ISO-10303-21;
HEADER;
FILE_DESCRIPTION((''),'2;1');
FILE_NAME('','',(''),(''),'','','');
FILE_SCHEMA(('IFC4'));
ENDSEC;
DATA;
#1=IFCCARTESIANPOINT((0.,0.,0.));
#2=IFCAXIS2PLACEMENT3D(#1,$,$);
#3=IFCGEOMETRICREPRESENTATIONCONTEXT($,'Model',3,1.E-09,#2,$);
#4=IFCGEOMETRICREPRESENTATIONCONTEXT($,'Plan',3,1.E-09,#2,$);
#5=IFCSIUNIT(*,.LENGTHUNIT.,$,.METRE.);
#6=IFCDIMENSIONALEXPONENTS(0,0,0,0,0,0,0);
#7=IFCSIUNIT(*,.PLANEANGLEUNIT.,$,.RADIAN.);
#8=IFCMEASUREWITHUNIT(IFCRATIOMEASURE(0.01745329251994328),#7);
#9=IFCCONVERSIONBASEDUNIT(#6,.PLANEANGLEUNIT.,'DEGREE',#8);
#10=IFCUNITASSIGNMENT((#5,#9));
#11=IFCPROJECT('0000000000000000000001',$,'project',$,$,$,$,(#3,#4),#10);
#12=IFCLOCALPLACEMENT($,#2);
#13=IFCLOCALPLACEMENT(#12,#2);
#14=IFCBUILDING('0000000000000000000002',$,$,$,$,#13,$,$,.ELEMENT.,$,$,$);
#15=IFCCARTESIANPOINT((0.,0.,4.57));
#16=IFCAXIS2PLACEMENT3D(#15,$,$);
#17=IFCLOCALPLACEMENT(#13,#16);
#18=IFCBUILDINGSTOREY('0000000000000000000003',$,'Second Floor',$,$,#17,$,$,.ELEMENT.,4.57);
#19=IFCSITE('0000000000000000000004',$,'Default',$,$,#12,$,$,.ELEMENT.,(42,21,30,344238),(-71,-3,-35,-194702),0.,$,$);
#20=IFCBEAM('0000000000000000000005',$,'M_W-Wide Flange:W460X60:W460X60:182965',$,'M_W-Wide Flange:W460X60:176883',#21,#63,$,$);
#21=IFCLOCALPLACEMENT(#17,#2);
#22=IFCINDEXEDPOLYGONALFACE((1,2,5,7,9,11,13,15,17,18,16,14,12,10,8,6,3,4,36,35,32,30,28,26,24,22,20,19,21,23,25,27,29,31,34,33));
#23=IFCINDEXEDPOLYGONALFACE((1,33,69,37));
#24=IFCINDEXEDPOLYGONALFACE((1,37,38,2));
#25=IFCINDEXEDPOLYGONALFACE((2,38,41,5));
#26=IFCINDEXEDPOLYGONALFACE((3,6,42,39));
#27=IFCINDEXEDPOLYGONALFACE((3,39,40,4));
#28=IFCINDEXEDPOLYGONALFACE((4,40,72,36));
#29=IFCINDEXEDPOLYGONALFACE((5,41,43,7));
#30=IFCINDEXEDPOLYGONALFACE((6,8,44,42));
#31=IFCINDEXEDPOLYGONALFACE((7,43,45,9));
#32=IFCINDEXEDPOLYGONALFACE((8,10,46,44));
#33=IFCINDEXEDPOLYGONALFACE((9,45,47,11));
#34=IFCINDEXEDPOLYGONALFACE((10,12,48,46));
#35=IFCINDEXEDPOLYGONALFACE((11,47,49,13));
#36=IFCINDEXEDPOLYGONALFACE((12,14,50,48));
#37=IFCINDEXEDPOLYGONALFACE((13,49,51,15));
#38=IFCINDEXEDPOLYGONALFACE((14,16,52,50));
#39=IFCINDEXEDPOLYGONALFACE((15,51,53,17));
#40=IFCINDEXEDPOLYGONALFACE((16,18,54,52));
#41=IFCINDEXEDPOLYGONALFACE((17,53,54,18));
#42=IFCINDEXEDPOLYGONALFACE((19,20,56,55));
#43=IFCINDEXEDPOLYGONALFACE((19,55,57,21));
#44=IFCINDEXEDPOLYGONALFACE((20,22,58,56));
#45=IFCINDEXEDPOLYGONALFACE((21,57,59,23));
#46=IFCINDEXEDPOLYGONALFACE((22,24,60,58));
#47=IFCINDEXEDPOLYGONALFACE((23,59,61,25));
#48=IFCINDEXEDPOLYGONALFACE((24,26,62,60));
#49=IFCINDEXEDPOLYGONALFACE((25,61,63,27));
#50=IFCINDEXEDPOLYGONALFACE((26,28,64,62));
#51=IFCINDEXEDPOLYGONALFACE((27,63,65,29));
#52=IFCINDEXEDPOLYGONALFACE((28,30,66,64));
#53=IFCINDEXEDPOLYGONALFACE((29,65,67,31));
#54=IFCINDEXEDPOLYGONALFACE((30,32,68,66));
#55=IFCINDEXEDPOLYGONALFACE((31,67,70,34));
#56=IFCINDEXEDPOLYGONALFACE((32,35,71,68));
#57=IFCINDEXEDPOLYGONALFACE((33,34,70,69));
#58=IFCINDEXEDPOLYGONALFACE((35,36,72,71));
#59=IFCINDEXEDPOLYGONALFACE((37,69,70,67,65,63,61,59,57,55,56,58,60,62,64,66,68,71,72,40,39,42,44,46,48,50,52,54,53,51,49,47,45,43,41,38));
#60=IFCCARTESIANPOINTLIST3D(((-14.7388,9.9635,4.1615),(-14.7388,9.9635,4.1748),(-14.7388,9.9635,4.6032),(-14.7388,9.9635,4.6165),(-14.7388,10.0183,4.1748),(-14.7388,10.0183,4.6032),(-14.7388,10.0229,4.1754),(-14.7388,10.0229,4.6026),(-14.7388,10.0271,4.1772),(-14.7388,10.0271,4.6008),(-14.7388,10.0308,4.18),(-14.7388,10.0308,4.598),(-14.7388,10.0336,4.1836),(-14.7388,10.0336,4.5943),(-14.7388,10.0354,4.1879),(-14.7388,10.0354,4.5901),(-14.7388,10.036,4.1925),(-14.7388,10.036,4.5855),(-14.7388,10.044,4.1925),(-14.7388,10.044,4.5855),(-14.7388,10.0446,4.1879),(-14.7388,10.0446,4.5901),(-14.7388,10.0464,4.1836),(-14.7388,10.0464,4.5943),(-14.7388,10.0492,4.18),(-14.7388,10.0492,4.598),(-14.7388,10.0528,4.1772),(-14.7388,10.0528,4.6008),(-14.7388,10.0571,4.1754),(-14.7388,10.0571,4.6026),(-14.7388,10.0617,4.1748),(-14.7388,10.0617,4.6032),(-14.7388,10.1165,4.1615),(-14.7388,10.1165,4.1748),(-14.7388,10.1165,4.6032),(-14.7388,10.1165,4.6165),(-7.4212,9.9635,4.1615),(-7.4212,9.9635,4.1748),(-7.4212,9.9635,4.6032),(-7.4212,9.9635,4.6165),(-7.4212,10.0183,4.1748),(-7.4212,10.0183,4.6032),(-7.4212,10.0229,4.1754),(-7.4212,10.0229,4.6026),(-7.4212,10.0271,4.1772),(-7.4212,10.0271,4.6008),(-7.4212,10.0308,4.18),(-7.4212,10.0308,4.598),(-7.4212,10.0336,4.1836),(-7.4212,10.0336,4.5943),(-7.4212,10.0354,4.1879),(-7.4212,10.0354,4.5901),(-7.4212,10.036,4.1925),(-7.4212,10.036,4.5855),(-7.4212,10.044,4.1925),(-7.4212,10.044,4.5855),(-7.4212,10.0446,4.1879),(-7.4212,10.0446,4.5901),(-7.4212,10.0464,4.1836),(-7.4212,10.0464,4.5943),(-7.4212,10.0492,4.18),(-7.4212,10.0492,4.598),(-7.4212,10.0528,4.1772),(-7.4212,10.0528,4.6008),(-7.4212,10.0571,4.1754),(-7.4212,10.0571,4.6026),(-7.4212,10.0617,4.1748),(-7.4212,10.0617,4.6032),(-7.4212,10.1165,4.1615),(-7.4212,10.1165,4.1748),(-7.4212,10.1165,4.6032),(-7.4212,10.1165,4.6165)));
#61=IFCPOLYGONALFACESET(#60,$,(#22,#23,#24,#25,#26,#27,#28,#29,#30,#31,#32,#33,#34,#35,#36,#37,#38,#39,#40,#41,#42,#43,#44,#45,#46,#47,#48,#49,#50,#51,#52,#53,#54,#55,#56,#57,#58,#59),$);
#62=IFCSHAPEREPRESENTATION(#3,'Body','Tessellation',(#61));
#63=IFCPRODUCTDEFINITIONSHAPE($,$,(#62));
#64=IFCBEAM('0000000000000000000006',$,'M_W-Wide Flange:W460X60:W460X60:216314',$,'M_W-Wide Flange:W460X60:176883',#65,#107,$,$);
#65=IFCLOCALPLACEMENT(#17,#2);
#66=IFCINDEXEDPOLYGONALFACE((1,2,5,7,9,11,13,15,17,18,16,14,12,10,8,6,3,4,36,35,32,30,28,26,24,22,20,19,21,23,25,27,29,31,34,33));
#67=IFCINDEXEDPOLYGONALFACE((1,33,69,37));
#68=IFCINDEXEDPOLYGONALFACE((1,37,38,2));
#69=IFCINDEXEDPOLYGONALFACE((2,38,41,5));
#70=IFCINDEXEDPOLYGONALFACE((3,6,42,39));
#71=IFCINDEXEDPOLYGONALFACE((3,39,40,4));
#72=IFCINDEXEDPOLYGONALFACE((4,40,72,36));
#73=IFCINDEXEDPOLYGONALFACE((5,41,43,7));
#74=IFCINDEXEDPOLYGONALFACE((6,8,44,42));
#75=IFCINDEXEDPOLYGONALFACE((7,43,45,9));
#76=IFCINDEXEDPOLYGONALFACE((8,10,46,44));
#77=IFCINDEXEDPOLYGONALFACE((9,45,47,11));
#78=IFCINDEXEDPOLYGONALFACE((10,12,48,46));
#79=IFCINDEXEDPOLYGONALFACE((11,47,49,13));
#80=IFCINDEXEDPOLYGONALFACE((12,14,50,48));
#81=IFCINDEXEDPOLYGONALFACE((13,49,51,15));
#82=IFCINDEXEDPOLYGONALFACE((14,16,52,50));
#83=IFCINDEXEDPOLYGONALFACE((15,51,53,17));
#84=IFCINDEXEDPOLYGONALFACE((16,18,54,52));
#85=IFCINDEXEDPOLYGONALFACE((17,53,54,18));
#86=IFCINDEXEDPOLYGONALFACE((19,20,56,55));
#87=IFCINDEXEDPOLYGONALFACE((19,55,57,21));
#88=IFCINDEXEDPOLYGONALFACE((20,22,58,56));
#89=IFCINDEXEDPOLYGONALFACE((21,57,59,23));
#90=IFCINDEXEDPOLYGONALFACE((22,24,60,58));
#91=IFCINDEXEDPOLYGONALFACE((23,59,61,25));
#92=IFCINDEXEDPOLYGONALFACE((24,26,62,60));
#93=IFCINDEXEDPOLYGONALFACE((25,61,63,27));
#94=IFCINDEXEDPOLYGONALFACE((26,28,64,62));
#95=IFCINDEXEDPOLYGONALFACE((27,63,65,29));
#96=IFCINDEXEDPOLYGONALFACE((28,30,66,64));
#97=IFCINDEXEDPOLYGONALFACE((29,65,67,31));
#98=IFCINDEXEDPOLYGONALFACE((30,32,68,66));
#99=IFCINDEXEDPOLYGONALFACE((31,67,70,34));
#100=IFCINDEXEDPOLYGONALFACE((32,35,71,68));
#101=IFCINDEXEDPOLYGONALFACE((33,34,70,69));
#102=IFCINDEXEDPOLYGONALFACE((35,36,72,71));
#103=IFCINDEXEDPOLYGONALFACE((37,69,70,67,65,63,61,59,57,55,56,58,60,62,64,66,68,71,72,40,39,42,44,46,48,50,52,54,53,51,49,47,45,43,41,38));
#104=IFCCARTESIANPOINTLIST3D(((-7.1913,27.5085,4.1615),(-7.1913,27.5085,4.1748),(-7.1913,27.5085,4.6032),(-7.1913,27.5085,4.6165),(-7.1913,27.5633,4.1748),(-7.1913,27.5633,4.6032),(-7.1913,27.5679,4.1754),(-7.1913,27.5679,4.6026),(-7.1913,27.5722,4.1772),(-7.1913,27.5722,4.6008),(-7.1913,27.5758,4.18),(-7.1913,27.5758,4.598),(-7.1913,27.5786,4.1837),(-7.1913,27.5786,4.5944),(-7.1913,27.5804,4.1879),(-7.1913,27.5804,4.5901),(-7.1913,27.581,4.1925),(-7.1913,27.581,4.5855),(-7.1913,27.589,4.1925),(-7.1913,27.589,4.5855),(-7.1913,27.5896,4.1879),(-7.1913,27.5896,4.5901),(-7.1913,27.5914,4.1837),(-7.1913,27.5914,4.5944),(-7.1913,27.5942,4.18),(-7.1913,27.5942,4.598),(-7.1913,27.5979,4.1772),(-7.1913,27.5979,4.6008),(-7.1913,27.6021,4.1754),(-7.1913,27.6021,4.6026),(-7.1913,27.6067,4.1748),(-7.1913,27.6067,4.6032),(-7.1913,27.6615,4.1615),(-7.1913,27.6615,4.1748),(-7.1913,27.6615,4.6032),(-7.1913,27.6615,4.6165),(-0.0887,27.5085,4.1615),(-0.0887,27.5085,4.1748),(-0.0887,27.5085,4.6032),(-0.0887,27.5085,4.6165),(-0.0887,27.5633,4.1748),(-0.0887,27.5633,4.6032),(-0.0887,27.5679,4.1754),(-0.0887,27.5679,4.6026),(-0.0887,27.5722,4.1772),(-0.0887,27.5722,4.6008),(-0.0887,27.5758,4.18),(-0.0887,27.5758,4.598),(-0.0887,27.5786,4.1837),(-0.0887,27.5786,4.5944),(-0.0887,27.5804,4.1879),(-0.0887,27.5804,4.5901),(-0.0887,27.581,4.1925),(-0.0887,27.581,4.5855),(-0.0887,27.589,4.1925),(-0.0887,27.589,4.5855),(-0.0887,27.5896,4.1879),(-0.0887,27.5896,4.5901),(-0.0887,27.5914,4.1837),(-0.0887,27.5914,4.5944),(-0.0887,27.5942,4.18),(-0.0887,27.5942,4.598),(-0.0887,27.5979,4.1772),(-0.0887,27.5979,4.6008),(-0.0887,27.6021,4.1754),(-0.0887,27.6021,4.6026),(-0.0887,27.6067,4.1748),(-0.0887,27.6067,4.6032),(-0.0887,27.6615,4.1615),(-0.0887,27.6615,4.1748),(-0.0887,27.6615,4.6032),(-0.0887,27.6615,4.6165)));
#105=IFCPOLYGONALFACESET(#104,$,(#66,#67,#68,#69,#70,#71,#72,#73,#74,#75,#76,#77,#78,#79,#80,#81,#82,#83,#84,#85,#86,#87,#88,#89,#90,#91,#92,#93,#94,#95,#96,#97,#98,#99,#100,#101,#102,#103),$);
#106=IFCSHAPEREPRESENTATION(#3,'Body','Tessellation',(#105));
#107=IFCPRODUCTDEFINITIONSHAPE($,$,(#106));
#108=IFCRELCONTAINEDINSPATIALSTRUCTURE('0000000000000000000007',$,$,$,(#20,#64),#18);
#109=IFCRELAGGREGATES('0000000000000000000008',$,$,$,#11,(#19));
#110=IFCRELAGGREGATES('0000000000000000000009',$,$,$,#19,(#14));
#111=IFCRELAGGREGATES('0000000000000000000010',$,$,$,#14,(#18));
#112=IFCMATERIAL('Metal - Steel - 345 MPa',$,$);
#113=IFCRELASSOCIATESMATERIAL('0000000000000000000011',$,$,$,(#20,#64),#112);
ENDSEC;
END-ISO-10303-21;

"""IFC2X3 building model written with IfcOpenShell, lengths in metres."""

from ifc_helpers import new_model, entity, si_unit, converted_unit, frame, frame_2d, origin, place, context, project, spatial, polyline, circle_curve, parameter, trimmed, segment, composite_curve, outline, extrude, material, element, save


model = new_model("IFC2X3")

# Units and contexts
model_context = context("Model", 3, precision=1e-09, world=origin())
plan_context = context("Plan", 3, precision=1e-09, world=origin())
ifc_project = project(units=[si_unit("LENGTHUNIT", "METRE"), converted_unit("PLANEANGLEUNIT", "DEGREE", entity("IfcRatioMeasure", 0.01745329251994328), si_unit("PLANEANGLEUNIT", "RADIAN"), dimensions=[0, 0, 0, 0, 0, 0, 0])], contexts=[model_context, plan_context])

# Site, building, storey
site_placement = place(None, origin())
site = spatial("IfcSite", under=ifc_project, at=site_placement, Name="Default", CompositionType="ELEMENT", RefLatitude=(42, 21, 30, 344238), RefLongitude=(-71, -3, -35, -194702), RefElevation=0.0)
building_placement = place(site_placement, origin())
building = spatial("IfcBuilding", under=site, at=building_placement, CompositionType="ELEMENT")
storey_placement = place(building_placement, frame((0.0, 0.0, 4.57)))
storey = spatial("IfcBuildingStorey", under=building, at=storey_placement, Name="Second Floor", CompositionType="ELEMENT", Elevation=4.57)

# Shared definitions
ifc_material = material(Name="Metal - Steel - 345 MPa")

# Beams
beam_1_placement = place(storey_placement, frame((-14.8775, 10.04, 4.6165), z_axis=(0.0, 0.0, 1.0), x_axis=(0.0, -1.0, 0.0)))
element("IfcBeam", 1, at=beam_1_placement, inside=storey, material=ifc_material, Name="M_W-Wide Flange:W460X60:W460X60:182965", ObjectType="M_W-Wide Flange:W460X60:176883", context=model_context, shape_type="SweptSolid", body=[
    extrude(outline(composite_curve([segment(polyline([(-0.0765, -0.2142), (-0.0765, -0.2275)]), True, "CONTINUOUS"), segment(polyline([(-0.0765, -0.2275), (0.0765, -0.2275)]), True, "CONTINUOUS"), segment(polyline([(0.0765, -0.2275), (0.0765, -0.2142)]), True, "CONTINUOUS"), segment(polyline([(0.0765, -0.2142), (0.0217, -0.2142)]), True, "CONTINUOUS"), segment(trimmed(circle_curve(frame_2d((0.0217, -0.1965), x_axis=(0.0, -1.0)), 0.0177), [parameter(270.0)], [parameter(360.0)], True, "PARAMETER"), False, "CONTINUOUS"), segment(polyline([(0.004, -0.1965), (0.004, 0.1965)]), True, "CONTINUOUS"), segment(trimmed(circle_curve(frame_2d((0.0217, 0.1965), x_axis=(-1.0, 0.0)), 0.0177), [parameter(270.0)], [parameter(360.0)], True, "PARAMETER"), False, "CONTINUOUS"), segment(polyline([(0.0217, 0.2142), (0.0765, 0.2142)]), True, "CONTINUOUS"), segment(polyline([(0.0765, 0.2142), (0.0765, 0.2275)]), True, "CONTINUOUS"), segment(polyline([(0.0765, 0.2275), (-0.0765, 0.2275)]), True, "CONTINUOUS"), segment(polyline([(-0.0765, 0.2275), (-0.0765, 0.2142)]), True, "CONTINUOUS"), segment(polyline([(-0.0765, 0.2142), (-0.0217, 0.2142)]), True, "CONTINUOUS"), segment(trimmed(circle_curve(frame_2d((-0.0217, 0.1965), x_axis=(0.0, 1.0)), 0.0177), [parameter(270.0)], [parameter(360.0)], True, "PARAMETER"), False, "CONTINUOUS"), segment(polyline([(-0.004, 0.1965), (-0.004, -0.1965)]), True, "CONTINUOUS"), segment(trimmed(circle_curve(frame_2d((-0.0217, -0.1965), x_axis=(1.0, 0.0)), 0.0177), [parameter(270.0)], [parameter(0.0)], True, "PARAMETER"), False, "CONTINUOUS"), segment(polyline([(-0.0217, -0.2142), (-0.0765, -0.2142)]), True, "CONTINUOUS")], self_intersect=False)), frame((0.0, 0.1387, -0.2275), z_axis=(0.0, -1.0, 0.0), x_axis=(1.0, 0.0, 0.0)), (0.0, 0.0, -1.0), 7.3176),
])
beam_2_placement = place(storey_placement, frame((-7.2774, 27.585, 4.6165), z_axis=(0.0, 0.0, 1.0), x_axis=(0.0, -1.0, 0.0)))
element("IfcBeam", 2, at=beam_2_placement, inside=storey, material=ifc_material, Name="M_W-Wide Flange:W460X60:W460X60:216314", ObjectType="M_W-Wide Flange:W460X60:176883", context=model_context, shape_type="SweptSolid", body=[
    extrude(outline(composite_curve([segment(polyline([(0.2142, -0.0765), (0.2275, -0.0765)]), True, "CONTINUOUS"), segment(polyline([(0.2275, -0.0765), (0.2275, 0.0765)]), True, "CONTINUOUS"), segment(polyline([(0.2275, 0.0765), (0.2142, 0.0765)]), True, "CONTINUOUS"), segment(polyline([(0.2142, 0.0765), (0.2142, 0.0217)]), True, "CONTINUOUS"), segment(trimmed(circle_curve(frame_2d((0.1965, 0.0217), x_axis=(0.0, 1.0)), 0.0177), [parameter(180.0)], [parameter(270.0)], True, "PARAMETER"), False, "CONTINUOUS"), segment(polyline([(0.1965, 0.004), (-0.1965, 0.004)]), True, "CONTINUOUS"), segment(trimmed(circle_curve(frame_2d((-0.1965, 0.0217), x_axis=(0.0, 1.0)), 0.0177), [parameter(90.0)], [parameter(180.0)], True, "PARAMETER"), False, "CONTINUOUS"), segment(polyline([(-0.2142, 0.0217), (-0.2142, 0.0765)]), True, "CONTINUOUS"), segment(polyline([(-0.2142, 0.0765), (-0.2275, 0.0765)]), True, "CONTINUOUS"), segment(polyline([(-0.2275, 0.0765), (-0.2275, -0.0765)]), True, "CONTINUOUS"), segment(polyline([(-0.2275, -0.0765), (-0.2142, -0.0765)]), True, "CONTINUOUS"), segment(polyline([(-0.2142, -0.0765), (-0.2142, -0.0217)]), True, "CONTINUOUS"), segment(trimmed(circle_curve(frame_2d((-0.1965, -0.0217), x_axis=(0.0, 1.0)), 0.0177), [parameter(360.0)], [parameter(90.0)], True, "PARAMETER"), False, "CONTINUOUS"), segment(polyline([(-0.1965, -0.004), (0.1965, -0.004)]), True, "CONTINUOUS"), segment(trimmed(circle_curve(frame_2d((0.1965, -0.0217), x_axis=(0.0, 1.0)), 0.0177), [parameter(270.0)], [parameter(0.0)], True, "PARAMETER"), False, "CONTINUOUS"), segment(polyline([(0.2142, -0.0217), (0.2142, -0.0765)]), True, "CONTINUOUS")], self_intersect=False)), frame((0.0, 0.0861, -0.2275), z_axis=(0.0, 1.0, 0.0), x_axis=(0.0, 0.0, -1.0)), (0.0, 0.0, 1.0), 7.1026),
])

save(model, "model.ifc")
